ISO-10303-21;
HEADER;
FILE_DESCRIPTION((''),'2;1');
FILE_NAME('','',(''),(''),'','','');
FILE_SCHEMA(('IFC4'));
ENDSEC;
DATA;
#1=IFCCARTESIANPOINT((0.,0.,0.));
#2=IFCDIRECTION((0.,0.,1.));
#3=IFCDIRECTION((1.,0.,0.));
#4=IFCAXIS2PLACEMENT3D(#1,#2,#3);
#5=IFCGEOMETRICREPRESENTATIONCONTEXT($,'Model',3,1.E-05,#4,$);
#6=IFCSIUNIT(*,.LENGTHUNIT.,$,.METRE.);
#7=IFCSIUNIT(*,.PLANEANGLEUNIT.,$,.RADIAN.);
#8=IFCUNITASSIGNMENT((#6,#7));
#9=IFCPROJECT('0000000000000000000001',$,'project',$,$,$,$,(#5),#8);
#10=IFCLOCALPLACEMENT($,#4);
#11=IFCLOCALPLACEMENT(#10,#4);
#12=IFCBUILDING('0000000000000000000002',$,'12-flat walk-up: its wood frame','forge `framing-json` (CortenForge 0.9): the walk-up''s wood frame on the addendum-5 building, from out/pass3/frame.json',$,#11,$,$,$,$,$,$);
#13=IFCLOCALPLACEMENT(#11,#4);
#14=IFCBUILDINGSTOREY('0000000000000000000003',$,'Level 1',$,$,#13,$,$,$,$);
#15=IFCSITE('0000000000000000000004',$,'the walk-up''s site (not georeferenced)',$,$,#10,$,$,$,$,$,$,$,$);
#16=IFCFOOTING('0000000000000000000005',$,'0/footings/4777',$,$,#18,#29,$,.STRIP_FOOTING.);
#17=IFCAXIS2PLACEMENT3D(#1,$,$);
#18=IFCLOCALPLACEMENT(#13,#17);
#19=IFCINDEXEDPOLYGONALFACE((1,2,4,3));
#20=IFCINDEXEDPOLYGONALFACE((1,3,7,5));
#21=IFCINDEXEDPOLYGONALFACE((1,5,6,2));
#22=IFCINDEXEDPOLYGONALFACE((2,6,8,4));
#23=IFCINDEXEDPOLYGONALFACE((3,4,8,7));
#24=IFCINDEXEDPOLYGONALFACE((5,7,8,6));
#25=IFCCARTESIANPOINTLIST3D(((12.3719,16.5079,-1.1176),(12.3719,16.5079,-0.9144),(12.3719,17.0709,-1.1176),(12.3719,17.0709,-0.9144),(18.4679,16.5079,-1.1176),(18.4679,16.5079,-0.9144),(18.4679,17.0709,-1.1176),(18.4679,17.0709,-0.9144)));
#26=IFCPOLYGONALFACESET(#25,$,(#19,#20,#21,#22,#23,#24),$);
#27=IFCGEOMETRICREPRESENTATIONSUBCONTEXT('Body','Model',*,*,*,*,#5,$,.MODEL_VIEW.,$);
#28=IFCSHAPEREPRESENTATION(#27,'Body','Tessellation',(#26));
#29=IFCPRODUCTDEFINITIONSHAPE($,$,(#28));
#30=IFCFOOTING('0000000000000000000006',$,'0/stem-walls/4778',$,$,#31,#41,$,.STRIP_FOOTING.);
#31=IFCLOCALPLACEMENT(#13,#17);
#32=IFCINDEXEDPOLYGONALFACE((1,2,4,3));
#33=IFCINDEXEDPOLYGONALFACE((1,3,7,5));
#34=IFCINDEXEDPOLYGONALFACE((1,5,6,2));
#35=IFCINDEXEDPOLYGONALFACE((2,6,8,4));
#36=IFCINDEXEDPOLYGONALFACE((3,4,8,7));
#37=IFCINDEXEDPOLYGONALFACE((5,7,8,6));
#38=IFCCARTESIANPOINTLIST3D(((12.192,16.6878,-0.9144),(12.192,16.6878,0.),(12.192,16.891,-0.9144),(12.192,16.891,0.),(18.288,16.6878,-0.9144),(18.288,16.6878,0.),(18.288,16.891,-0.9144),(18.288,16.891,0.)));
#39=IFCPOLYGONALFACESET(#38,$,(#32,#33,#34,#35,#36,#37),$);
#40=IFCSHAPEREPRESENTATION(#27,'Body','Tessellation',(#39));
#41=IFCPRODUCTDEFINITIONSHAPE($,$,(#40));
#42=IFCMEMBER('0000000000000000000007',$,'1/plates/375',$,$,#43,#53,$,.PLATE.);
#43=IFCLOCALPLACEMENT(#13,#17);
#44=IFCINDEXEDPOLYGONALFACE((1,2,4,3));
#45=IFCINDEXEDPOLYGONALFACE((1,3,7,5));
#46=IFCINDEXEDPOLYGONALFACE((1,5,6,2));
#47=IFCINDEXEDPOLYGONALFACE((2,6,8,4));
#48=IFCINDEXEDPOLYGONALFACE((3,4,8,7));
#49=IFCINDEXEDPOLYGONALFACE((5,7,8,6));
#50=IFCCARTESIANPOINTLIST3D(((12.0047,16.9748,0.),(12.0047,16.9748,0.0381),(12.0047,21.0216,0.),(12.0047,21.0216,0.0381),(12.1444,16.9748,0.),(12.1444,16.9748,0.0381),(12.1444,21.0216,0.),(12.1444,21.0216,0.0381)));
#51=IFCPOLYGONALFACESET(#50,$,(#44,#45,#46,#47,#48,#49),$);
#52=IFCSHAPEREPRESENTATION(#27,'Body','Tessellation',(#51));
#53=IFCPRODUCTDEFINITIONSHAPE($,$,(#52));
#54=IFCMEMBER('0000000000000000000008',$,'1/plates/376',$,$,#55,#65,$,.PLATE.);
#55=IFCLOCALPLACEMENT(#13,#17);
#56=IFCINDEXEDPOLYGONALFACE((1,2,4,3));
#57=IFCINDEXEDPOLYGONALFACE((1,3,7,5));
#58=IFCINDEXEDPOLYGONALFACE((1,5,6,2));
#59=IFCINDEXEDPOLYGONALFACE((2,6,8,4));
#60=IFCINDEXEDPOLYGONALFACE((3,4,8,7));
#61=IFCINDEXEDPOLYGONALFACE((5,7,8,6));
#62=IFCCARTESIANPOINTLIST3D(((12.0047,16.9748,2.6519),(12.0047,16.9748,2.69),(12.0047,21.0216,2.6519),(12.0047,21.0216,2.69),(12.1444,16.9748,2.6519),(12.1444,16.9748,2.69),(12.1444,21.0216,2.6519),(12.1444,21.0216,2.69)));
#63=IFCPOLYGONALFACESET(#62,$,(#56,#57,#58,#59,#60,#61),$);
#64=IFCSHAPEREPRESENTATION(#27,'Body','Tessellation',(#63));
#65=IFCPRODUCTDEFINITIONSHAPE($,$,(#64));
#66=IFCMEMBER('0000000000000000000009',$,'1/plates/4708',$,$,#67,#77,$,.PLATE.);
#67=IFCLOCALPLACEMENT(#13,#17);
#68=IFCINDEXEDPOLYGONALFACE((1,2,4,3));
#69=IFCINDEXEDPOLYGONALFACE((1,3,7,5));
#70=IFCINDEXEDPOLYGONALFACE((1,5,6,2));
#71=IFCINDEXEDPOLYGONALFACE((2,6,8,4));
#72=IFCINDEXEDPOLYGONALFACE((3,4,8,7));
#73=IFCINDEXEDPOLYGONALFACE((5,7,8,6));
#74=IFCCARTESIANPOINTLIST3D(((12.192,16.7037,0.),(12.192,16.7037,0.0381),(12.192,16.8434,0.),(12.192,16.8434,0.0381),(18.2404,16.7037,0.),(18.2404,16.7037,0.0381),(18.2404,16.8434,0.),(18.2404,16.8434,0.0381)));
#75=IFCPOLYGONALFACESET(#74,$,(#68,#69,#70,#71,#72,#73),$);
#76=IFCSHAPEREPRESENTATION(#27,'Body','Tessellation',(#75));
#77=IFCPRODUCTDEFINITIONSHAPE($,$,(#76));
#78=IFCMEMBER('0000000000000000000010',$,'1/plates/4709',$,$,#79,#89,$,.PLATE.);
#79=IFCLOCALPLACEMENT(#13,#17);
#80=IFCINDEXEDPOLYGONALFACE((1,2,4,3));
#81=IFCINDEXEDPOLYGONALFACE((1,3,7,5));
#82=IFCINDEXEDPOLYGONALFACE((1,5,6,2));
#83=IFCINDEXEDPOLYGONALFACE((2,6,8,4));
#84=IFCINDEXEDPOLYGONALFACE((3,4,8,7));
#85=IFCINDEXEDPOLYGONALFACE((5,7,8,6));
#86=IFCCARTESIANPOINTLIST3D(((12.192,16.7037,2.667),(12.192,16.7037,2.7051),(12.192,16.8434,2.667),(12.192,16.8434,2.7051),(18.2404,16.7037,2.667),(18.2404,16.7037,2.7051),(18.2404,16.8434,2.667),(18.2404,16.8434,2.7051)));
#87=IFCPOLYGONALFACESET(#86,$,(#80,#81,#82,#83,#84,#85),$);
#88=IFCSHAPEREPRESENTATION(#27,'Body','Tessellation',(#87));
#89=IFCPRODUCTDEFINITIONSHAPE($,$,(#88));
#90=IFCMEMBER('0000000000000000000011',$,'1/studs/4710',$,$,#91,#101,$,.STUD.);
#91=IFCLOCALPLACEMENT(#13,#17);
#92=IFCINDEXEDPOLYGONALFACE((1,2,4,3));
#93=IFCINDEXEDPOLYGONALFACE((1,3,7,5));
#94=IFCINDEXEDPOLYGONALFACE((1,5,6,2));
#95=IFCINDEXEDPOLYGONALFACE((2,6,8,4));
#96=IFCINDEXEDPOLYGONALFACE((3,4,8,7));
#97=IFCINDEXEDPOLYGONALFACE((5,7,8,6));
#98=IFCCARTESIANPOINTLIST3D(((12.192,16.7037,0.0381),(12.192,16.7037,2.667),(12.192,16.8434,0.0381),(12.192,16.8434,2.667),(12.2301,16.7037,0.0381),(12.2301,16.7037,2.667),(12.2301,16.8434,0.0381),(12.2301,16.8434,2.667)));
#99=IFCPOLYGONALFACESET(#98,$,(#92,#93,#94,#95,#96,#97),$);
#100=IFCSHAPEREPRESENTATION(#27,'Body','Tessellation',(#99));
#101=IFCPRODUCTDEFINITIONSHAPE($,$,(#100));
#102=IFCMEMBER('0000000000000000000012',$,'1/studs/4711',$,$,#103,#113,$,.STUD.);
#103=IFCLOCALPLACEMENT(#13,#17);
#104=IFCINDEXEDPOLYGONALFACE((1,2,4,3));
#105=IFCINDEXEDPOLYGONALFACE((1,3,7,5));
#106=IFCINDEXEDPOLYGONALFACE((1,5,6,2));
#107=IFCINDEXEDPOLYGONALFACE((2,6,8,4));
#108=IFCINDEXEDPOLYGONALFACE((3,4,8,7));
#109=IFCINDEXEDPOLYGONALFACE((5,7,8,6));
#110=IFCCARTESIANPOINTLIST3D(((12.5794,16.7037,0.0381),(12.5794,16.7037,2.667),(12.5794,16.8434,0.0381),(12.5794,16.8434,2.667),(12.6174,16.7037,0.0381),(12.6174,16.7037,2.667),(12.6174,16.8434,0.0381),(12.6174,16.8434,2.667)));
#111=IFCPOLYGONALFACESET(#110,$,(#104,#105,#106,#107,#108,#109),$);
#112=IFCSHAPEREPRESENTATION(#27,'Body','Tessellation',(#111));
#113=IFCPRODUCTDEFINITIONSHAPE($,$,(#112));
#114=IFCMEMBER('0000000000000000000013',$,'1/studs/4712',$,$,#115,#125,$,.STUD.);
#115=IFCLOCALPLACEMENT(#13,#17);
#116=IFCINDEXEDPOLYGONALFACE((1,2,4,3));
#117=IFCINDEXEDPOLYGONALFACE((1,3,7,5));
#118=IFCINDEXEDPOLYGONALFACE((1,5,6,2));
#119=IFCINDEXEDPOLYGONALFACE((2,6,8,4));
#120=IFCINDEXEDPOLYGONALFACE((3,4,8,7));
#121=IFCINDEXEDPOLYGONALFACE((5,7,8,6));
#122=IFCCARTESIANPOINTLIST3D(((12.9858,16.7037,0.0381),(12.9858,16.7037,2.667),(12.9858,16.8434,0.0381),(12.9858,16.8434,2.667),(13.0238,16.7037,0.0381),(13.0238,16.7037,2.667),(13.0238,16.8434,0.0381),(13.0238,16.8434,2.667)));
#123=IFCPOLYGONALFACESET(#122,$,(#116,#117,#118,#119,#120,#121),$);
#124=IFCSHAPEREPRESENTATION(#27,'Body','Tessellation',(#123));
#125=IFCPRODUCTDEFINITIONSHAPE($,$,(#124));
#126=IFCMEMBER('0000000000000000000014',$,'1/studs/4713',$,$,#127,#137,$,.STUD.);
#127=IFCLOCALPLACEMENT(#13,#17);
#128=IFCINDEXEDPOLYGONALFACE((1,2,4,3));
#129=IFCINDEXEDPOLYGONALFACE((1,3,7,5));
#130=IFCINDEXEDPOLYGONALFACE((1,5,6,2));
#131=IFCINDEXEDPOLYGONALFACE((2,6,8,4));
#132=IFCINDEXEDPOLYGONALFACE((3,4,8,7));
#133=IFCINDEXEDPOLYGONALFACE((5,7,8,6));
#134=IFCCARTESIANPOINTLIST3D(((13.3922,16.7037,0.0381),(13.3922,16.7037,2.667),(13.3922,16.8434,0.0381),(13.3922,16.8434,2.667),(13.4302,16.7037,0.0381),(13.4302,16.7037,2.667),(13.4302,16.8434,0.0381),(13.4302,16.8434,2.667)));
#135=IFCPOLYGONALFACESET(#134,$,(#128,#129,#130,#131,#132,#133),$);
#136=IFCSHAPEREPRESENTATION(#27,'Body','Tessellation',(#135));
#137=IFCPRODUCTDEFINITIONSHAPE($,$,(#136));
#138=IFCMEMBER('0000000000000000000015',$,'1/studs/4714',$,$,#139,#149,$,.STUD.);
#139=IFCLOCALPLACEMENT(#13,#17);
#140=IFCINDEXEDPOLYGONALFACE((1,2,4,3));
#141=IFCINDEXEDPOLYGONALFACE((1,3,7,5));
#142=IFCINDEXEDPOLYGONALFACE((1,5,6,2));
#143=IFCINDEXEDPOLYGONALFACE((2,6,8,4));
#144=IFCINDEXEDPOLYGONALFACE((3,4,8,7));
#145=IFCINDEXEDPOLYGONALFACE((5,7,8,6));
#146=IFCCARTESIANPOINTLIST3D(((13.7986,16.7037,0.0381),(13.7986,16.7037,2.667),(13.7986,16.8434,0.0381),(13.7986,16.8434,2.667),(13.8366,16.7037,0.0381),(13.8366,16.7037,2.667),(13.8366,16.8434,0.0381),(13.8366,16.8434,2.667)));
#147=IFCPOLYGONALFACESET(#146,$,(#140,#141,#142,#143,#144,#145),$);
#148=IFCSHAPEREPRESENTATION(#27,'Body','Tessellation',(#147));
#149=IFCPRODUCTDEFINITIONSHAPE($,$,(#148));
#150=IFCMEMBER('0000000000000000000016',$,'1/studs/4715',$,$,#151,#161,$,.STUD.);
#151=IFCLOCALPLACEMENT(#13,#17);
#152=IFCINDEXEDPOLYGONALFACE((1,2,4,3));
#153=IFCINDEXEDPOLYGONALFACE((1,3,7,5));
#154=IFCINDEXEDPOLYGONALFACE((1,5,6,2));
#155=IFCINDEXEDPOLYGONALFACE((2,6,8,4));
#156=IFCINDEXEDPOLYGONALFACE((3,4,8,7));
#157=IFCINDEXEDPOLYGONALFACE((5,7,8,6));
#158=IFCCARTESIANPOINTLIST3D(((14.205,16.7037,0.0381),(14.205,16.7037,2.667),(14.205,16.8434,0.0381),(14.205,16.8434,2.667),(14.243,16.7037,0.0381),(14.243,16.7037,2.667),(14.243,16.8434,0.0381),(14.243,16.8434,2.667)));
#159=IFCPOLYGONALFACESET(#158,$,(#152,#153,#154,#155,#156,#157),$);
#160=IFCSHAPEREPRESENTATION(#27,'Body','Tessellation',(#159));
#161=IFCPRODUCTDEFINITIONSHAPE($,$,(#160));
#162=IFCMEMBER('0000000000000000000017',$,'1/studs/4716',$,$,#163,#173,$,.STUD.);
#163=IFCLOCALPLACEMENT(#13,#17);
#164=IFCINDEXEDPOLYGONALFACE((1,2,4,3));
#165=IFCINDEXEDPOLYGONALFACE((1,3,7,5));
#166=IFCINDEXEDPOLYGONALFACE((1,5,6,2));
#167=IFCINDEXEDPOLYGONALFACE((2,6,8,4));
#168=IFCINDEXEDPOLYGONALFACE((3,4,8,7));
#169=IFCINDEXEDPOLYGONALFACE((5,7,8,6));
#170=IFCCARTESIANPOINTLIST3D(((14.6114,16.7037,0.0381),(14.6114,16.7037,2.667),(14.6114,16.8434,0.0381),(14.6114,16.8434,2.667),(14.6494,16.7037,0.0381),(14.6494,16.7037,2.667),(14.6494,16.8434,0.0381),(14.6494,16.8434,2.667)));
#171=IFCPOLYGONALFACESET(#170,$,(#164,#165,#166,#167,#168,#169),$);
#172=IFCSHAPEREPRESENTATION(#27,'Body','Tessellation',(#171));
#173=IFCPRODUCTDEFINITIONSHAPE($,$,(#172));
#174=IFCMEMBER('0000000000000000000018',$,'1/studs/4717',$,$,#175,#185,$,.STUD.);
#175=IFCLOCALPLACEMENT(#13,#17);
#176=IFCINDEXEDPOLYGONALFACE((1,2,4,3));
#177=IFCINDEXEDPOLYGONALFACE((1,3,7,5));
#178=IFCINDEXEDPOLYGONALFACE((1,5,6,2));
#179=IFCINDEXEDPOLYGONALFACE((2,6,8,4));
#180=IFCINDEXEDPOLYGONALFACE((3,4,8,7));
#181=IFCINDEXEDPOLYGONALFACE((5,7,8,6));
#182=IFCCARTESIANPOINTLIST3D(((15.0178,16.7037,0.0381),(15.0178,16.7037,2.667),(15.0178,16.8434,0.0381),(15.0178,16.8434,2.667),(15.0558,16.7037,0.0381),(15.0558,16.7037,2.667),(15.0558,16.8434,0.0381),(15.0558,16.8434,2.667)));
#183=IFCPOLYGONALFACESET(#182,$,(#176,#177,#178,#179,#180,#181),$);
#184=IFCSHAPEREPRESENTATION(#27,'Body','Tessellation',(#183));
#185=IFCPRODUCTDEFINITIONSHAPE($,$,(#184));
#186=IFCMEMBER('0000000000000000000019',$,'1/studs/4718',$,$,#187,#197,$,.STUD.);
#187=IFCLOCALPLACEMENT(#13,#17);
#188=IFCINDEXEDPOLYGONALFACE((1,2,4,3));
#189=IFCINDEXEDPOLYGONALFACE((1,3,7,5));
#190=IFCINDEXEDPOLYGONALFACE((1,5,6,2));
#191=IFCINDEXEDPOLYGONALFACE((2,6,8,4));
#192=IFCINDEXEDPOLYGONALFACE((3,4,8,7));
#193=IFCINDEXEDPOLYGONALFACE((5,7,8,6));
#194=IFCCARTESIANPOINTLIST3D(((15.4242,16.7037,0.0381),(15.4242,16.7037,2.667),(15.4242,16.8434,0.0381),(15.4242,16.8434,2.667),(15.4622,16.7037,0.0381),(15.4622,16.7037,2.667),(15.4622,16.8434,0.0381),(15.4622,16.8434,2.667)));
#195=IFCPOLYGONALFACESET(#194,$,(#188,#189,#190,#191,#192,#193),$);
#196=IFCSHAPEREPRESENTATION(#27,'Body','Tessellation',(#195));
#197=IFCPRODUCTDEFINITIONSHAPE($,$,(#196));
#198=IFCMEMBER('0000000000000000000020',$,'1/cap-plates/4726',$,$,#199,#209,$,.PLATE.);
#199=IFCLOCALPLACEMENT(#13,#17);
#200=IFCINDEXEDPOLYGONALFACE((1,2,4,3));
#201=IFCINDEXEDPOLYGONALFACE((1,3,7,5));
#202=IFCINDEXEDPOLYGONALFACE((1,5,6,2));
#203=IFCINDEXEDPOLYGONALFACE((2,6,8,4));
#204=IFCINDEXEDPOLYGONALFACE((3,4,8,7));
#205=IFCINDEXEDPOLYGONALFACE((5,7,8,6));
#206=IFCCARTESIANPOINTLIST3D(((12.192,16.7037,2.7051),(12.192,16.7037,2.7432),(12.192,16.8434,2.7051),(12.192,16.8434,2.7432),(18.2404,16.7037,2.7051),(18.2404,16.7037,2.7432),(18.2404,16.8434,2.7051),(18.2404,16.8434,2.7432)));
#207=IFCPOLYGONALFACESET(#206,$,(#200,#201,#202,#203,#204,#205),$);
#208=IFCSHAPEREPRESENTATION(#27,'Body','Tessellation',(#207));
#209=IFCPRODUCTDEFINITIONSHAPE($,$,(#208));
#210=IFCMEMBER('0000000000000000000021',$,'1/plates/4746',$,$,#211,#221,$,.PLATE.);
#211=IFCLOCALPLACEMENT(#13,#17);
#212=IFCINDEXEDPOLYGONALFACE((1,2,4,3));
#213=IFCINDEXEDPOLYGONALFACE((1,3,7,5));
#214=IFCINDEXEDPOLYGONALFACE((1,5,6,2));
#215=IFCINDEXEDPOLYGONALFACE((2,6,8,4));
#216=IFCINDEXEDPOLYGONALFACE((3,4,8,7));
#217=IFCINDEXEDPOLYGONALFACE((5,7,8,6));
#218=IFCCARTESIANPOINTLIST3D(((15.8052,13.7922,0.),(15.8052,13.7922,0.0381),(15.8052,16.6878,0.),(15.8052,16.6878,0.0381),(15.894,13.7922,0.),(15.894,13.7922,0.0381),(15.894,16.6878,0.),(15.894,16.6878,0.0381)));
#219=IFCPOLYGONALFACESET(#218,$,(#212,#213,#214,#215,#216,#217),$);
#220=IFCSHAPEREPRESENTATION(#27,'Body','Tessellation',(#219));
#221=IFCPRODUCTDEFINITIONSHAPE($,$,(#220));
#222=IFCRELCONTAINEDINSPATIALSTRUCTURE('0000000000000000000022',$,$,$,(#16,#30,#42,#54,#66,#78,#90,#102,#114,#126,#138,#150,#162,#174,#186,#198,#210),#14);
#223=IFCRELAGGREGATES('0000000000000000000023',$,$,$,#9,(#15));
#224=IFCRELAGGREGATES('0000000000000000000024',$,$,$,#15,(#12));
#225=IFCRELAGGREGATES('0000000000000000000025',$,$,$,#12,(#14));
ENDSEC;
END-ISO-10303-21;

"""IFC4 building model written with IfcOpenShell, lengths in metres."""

from ifc_helpers import new_model, si_unit, frame, frame_2d, origin, origin_with_axes, place, context, subcontext, project, spatial, rectangle, extrude, element, save


model = new_model("IFC4")

# Units and contexts
model_context = context("Model", 3, precision=1e-05, world=origin_with_axes())
body_context = subcontext(model_context, "Body", "Model", "MODEL_VIEW")
ifc_project = project(units=[si_unit("LENGTHUNIT", "METRE"), si_unit("PLANEANGLEUNIT", "RADIAN")], contexts=[model_context])

# Site, building, storey
site_placement = place(None, origin_with_axes())
site = spatial("IfcSite", under=ifc_project, at=site_placement, Name="the walk-up's site (not georeferenced)")
building_placement = place(site_placement, origin_with_axes())
building = spatial("IfcBuilding", under=site, at=building_placement, Name="12-flat walk-up: its wood frame", Description="forge `framing-json` (CortenForge 0.9): the walk-up's wood frame on the addendum-5 building, from out/pass3/frame.json")
storey_placement = place(building_placement, origin_with_axes())
storey = spatial("IfcBuildingStorey", under=building, at=storey_placement, Name="Level 1")

# Footings
footing_1_placement = place(storey_placement, frame((12.3719, 16.5079, -1.1176), z_axis=(0.0, 0.0, 1.0), x_axis=(1.0, 0.0, 0.0)))
element("IfcFooting", 1, at=footing_1_placement, inside=storey, Name="0/footings/4777", PredefinedType="STRIP_FOOTING", context=body_context, shape_type="SweptSolid", body=[
    extrude(rectangle(XDim=6.096, YDim=0.5631, at=frame_2d((3.048, 0.2815))), origin(), (0.0, 0.0, 1.0), 0.2032),
])
footing_2_placement = place(storey_placement, frame((12.192, 16.6878, -0.9144), z_axis=(0.0, 0.0, 1.0), x_axis=(1.0, 0.0, 0.0)))
element("IfcFooting", 2, at=footing_2_placement, inside=storey, Name="0/stem-walls/4778", PredefinedType="STRIP_FOOTING", context=body_context, shape_type="SweptSolid", body=[
    extrude(rectangle(XDim=6.096, YDim=0.2032, at=frame_2d((3.048, 0.1016))), origin(), (0.0, 0.0, 1.0), 0.9144),
])

# Members
member_1_placement = place(storey_placement, frame((12.0047, 16.9748, 0.0), z_axis=(0.0, 0.0, 1.0), x_axis=(1.0, 0.0, 0.0)))
element("IfcMember", 3, at=member_1_placement, inside=storey, Name="1/plates/375", PredefinedType="PLATE", context=body_context, shape_type="SweptSolid", body=[
    extrude(rectangle(XDim=0.1397, YDim=4.0468, at=frame_2d((0.0698, 2.0234))), origin(), (0.0, 0.0, 1.0), 0.0381),
])
member_2_placement = place(storey_placement, frame((12.0047, 16.9748, 2.6519), z_axis=(0.0, 0.0, 1.0), x_axis=(1.0, 0.0, 0.0)))
element("IfcMember", 4, at=member_2_placement, inside=storey, Name="1/plates/376", PredefinedType="PLATE", context=body_context, shape_type="SweptSolid", body=[
    extrude(rectangle(XDim=0.1397, YDim=4.0468, at=frame_2d((0.0698, 2.0234))), origin(), (0.0, 0.0, 1.0), 0.0381),
])
member_3_placement = place(storey_placement, frame((12.192, 16.7037, 0.0), z_axis=(0.0, 0.0, 1.0), x_axis=(1.0, 0.0, 0.0)))
element("IfcMember", 5, at=member_3_placement, inside=storey, Name="1/plates/4708", PredefinedType="PLATE", context=body_context, shape_type="SweptSolid", body=[
    extrude(rectangle(XDim=6.0484, YDim=0.1397, at=frame_2d((3.0242, 0.0699))), origin(), (0.0, 0.0, 1.0), 0.0381),
])
member_4_placement = place(storey_placement, frame((12.192, 16.7037, 2.667), z_axis=(0.0, 0.0, 1.0), x_axis=(1.0, 0.0, 0.0)))
element("IfcMember", 6, at=member_4_placement, inside=storey, Name="1/plates/4709", PredefinedType="PLATE", context=body_context, shape_type="SweptSolid", body=[
    extrude(rectangle(XDim=6.0484, YDim=0.1397, at=frame_2d((3.0242, 0.0699))), origin(), (0.0, 0.0, 1.0), 0.0381),
])
for number, where, z_axis, x_axis, name in (
    (7, (12.192, 16.7037, 0.0381), (0.0, 0.0, 1.0), (1.0, 0.0, 0.0), "1/studs/4710"),
    (8, (12.5793, 16.7037, 0.0381), (0.0, 0.0, 1.0), (1.0, 0.0, 0.0), "1/studs/4711"),
    (9, (12.9857, 16.7037, 0.0381), (0.0, 0.0, 1.0), (1.0, 0.0, 0.0), "1/studs/4712"),
):
    element("IfcMember", number, at=place(storey_placement, frame(where, z_axis=z_axis, x_axis=x_axis)), inside=storey, Name=name, PredefinedType="STUD", context=body_context, shape_type="SweptSolid", body=[
        extrude(rectangle(XDim=0.0381, YDim=0.1397, at=frame_2d((0.0191, 0.0699))), origin(), (0.0, 0.0, 1.0), 2.6289),
    ])
member_5_placement = place(storey_placement, frame((13.3922, 16.7037, 0.0381), z_axis=(0.0, 0.0, 1.0), x_axis=(1.0, 0.0, 0.0)))
element("IfcMember", 10, at=member_5_placement, inside=storey, Name="1/studs/4713", PredefinedType="STUD", context=body_context, shape_type="SweptSolid", body=[
    extrude(rectangle(XDim=0.0381, YDim=0.1397, at=frame_2d((0.019, 0.0699))), origin(), (0.0, 0.0, 1.0), 2.6289),
])
for number, where, z_axis, x_axis, name in (
    (11, (13.7986, 16.7037, 0.0381), (0.0, 0.0, 1.0), (1.0, 0.0, 0.0), "1/studs/4714"),
    (12, (14.205, 16.7037, 0.0381), (0.0, 0.0, 1.0), (1.0, 0.0, 0.0), "1/studs/4715"),
    (13, (14.6113, 16.7037, 0.0381), (0.0, 0.0, 1.0), (1.0, 0.0, 0.0), "1/studs/4716"),
    (14, (15.0177, 16.7037, 0.0381), (0.0, 0.0, 1.0), (1.0, 0.0, 0.0), "1/studs/4717"),
    (15, (15.4241, 16.7037, 0.0381), (0.0, 0.0, 1.0), (1.0, 0.0, 0.0), "1/studs/4718"),
):
    element("IfcMember", number, at=place(storey_placement, frame(where, z_axis=z_axis, x_axis=x_axis)), inside=storey, Name=name, PredefinedType="STUD", context=body_context, shape_type="SweptSolid", body=[
        extrude(rectangle(XDim=0.0381, YDim=0.1397, at=frame_2d((0.0191, 0.0699))), origin(), (0.0, 0.0, 1.0), 2.6289),
    ])
member_6_placement = place(storey_placement, frame((12.192, 16.7037, 2.7051), z_axis=(0.0, 0.0, 1.0), x_axis=(1.0, 0.0, 0.0)))
element("IfcMember", 16, at=member_6_placement, inside=storey, Name="1/cap-plates/4726", PredefinedType="PLATE", context=body_context, shape_type="SweptSolid", body=[
    extrude(rectangle(XDim=6.0484, YDim=0.1397, at=frame_2d((3.0242, 0.0699))), origin(), (0.0, 0.0, 1.0), 0.0381),
])
member_7_placement = place(storey_placement, frame((15.8051, 13.7922, 0.0), z_axis=(0.0, 0.0, 1.0), x_axis=(1.0, 0.0, 0.0)))
element("IfcMember", 17, at=member_7_placement, inside=storey, Name="1/plates/4746", PredefinedType="PLATE", context=body_context, shape_type="SweptSolid", body=[
    extrude(rectangle(XDim=0.0889, YDim=2.8956, at=frame_2d((0.0445, 1.4478))), origin(), (0.0, 0.0, 1.0), 0.0381),
])

save(model, "model.ifc")
